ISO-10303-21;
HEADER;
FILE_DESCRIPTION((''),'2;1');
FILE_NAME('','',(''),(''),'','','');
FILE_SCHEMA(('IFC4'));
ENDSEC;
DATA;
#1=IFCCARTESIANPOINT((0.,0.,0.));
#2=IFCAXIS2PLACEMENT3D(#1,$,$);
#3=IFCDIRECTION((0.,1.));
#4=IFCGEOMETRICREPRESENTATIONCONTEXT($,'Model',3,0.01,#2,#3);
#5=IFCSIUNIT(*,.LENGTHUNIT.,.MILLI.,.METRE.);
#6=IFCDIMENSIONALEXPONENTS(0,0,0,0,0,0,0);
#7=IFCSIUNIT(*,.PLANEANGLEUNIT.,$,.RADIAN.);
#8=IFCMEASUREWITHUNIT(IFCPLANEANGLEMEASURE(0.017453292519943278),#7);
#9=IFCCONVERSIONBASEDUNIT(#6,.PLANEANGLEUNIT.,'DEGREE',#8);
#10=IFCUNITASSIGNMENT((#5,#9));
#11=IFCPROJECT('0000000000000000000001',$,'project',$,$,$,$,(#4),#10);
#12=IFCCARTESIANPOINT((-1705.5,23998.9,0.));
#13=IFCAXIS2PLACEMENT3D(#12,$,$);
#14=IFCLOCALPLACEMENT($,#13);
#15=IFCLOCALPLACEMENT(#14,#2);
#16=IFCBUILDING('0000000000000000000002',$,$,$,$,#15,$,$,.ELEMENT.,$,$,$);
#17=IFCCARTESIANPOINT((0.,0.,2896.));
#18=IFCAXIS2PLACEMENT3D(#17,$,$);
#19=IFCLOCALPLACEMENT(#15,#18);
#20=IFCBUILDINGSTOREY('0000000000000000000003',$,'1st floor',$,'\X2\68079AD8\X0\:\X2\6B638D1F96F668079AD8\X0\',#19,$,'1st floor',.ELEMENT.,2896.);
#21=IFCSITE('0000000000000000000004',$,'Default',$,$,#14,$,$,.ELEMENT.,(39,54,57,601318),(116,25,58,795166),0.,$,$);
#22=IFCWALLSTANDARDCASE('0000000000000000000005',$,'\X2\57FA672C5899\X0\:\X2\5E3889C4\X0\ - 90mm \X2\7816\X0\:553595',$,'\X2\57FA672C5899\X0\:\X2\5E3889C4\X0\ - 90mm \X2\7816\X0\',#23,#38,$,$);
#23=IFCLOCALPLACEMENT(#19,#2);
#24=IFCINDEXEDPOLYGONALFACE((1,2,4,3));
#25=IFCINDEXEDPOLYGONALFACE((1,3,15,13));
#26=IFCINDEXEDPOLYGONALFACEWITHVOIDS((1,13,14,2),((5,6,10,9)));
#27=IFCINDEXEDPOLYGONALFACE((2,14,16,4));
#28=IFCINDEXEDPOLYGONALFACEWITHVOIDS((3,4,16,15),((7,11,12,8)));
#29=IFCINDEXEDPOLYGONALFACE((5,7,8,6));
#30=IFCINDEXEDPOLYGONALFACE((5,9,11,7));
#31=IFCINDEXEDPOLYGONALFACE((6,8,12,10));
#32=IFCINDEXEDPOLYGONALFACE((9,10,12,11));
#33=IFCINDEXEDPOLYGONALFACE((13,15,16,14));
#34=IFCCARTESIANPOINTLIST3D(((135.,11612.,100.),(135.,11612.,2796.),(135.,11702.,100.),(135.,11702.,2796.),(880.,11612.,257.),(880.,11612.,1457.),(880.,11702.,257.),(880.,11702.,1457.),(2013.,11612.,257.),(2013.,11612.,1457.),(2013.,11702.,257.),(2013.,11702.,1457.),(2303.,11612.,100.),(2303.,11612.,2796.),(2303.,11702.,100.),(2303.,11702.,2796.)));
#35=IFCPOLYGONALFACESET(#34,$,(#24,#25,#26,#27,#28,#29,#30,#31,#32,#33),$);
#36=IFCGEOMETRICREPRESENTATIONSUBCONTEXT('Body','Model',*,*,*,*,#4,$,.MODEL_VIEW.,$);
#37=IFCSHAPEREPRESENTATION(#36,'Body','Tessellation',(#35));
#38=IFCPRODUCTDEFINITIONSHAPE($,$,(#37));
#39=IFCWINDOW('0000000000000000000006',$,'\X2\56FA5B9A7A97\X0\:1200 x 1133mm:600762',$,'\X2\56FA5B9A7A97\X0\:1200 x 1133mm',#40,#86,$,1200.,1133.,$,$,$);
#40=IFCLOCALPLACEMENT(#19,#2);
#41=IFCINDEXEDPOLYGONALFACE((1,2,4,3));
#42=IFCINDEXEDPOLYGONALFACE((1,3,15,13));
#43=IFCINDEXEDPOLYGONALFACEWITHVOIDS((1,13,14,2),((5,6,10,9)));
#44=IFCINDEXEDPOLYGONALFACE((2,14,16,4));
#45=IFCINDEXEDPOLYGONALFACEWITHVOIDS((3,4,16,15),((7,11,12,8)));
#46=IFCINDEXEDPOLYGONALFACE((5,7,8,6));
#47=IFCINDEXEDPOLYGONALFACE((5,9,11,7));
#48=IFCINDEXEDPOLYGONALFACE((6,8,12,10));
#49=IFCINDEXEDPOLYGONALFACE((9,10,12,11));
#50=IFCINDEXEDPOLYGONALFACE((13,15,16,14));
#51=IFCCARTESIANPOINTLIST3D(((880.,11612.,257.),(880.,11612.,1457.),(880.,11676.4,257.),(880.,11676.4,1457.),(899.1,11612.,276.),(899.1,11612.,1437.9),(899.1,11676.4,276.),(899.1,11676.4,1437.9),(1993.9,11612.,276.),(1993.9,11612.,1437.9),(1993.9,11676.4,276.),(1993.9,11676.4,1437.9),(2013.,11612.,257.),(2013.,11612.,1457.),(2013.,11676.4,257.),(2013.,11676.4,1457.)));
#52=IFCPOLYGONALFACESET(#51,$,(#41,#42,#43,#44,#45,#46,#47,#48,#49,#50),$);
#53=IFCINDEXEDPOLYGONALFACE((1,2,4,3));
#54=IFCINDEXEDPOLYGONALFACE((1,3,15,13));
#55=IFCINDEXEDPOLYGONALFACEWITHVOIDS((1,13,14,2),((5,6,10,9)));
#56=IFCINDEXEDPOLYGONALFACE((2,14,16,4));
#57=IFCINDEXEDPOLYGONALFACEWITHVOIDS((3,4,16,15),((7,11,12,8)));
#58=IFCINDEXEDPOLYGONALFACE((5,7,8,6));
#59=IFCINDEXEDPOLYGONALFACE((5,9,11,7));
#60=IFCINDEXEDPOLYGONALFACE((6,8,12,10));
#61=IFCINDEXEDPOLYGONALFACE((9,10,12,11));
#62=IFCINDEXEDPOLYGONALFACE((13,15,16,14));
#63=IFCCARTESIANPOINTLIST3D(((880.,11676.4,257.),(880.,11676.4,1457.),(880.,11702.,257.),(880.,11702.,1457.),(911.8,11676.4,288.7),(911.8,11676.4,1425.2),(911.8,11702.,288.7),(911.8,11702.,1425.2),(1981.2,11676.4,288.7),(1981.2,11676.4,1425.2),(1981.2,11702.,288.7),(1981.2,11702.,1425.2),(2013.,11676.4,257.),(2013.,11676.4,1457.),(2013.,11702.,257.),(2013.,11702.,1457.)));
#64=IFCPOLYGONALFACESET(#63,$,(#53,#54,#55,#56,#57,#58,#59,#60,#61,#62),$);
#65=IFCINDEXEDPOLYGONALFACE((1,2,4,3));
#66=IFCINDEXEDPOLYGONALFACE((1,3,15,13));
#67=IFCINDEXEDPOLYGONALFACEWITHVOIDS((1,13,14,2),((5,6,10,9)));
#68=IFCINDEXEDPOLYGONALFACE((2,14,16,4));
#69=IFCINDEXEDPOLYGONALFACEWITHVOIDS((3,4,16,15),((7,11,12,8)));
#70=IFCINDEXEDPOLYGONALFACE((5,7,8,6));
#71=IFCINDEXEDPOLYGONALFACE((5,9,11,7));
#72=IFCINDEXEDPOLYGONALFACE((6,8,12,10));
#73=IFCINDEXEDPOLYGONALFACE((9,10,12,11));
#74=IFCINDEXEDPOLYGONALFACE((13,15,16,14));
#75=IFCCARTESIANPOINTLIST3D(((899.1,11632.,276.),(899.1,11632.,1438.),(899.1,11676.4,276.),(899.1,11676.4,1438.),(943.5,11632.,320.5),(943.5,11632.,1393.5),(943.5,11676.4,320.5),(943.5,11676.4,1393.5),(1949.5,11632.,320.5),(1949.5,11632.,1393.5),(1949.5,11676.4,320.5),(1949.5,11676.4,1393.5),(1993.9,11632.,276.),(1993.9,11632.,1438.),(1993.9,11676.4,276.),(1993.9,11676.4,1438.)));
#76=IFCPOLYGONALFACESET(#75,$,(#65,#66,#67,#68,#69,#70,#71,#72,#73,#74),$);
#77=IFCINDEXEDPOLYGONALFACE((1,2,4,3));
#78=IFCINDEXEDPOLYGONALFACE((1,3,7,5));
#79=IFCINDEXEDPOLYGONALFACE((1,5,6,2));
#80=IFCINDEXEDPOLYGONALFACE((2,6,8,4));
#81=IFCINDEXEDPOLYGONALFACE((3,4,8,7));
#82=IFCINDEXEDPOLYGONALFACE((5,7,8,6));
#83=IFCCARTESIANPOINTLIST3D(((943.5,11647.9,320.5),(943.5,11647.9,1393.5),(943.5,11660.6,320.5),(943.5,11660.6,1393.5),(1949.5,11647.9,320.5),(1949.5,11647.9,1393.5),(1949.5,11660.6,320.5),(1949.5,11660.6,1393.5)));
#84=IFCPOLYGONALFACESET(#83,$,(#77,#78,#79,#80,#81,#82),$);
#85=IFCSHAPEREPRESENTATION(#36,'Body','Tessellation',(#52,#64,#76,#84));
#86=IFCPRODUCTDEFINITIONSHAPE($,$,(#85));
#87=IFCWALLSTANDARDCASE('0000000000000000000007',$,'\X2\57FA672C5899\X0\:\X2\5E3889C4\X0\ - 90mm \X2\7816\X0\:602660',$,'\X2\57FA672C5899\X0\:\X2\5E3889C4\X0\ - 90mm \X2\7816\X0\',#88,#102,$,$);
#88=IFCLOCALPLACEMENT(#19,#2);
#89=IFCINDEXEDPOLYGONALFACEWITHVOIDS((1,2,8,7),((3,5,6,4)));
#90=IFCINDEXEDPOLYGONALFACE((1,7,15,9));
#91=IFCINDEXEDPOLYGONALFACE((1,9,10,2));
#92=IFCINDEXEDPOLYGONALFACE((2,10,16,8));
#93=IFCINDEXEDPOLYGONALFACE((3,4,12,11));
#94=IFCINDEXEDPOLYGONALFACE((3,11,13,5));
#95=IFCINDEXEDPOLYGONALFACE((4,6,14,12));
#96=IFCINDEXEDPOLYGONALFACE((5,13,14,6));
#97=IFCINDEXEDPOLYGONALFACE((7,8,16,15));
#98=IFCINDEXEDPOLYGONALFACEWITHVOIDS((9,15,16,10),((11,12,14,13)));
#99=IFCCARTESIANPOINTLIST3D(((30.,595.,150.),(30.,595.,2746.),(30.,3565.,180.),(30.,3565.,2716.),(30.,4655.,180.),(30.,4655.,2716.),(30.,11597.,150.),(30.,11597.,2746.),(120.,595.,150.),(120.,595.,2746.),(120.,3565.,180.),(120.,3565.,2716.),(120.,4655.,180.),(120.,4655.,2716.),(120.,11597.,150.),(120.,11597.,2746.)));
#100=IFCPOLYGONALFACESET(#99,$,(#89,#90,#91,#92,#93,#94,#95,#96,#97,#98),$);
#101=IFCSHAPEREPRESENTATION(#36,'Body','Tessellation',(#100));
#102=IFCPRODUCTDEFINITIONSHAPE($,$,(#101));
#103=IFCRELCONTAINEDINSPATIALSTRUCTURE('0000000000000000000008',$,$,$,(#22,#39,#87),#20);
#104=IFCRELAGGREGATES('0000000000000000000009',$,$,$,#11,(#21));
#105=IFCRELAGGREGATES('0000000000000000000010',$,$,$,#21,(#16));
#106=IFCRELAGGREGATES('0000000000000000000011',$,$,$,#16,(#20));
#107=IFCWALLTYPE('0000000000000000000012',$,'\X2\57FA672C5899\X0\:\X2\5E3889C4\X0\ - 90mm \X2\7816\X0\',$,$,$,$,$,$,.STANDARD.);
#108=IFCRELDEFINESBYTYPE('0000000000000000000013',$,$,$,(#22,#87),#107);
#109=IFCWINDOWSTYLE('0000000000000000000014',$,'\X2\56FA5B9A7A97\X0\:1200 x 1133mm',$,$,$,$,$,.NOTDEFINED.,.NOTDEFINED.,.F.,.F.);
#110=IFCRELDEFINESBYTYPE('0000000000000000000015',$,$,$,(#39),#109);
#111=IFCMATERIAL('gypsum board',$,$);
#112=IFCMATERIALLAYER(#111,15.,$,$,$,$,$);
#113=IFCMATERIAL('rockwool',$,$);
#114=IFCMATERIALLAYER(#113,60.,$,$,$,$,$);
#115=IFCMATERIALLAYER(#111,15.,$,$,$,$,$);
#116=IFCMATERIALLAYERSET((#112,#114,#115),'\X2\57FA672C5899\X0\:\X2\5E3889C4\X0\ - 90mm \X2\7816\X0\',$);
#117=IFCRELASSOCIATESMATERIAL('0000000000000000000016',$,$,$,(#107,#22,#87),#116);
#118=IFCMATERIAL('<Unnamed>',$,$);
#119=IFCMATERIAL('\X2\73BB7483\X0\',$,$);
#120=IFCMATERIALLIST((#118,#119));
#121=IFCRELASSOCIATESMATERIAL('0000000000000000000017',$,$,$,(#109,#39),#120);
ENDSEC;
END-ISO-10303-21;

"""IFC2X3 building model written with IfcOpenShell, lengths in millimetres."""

from ifc_helpers import new_model, entity, si_unit, converted_unit, direction, frame, frame_2d, origin, origin_2d_with_axis, place, context, subcontext, project, spatial, polyline, rectangle, outline, extrude, source, transform, mapped, material, material_list, layer, layer_set, layer_usage, type_object, type_shapes, element, fill, save


model = new_model("IFC2X3")

# Units and contexts
model_context = context("Model", 3, precision=0.01, world=origin(), true_north=direction((0.0, 1.0)))
body_context = subcontext(model_context, "Body", "Model", "MODEL_VIEW")
ifc_project = project(units=[si_unit("LENGTHUNIT", "METRE", prefix="MILLI"), converted_unit("PLANEANGLEUNIT", "DEGREE", entity("IfcPlaneAngleMeasure", 0.017453292519943278), si_unit("PLANEANGLEUNIT", "RADIAN"), dimensions=[0, 0, 0, 0, 0, 0, 0])], contexts=[model_context])

# Site, building, storey
site_placement = place(None, frame((-1705.5, 23998.9, 0.0)))
site = spatial("IfcSite", under=ifc_project, at=site_placement, Name="Default", CompositionType="ELEMENT", RefLatitude=(39, 54, 57, 601318), RefLongitude=(116, 25, 58, 795166), RefElevation=0.0)
building_placement = place(site_placement, origin())
building = spatial("IfcBuilding", under=site, at=building_placement, CompositionType="ELEMENT")
storey_placement = place(building_placement, frame((0.0, 0.0, 2896.0)))
storey = spatial("IfcBuildingStorey", under=building, at=storey_placement, Name="1st floor", ObjectType="标高:正负零标高", LongName="1st floor", CompositionType="ELEMENT", Elevation=2896.0)

# Shared definitions
ifc_material_1 = material(Name="gypsum board")
ifc_layer_1 = layer(ifc_material_1, 15.0)
ifc_material_2 = material(Name="rockwool")
ifc_layer_2 = layer(ifc_material_2, 60.0)
ifc_layer_3 = layer(ifc_material_1, 15.0)
ifc_layer_set = layer_set([ifc_layer_1, ifc_layer_2, ifc_layer_3], Name="基本墙:常规 - 90mm 砖")
wall_type = type_object("IfcWallType", Name="基本墙:常规 - 90mm 砖", PredefinedType="STANDARD", material=ifc_layer_set)

# Wall, opening, window
ifc_layer_usage_1 = layer_usage(ifc_layer_set, "AXIS2", "NEGATIVE", 45.0)
wall_1_placement = place(storey_placement, frame((2303.0, 11657.0, 100.0), z_axis=(0.0, 0.0, 1.0), x_axis=(-1.0, 0.0, 0.0)))
wall_1 = element("IfcWallStandardCase", 1, at=wall_1_placement, inside=storey, type_object=wall_type, material=ifc_layer_usage_1, Name="基本墙:常规 - 90mm 砖:553595", ObjectType="基本墙:常规 - 90mm 砖", context=body_context, shape_type="SweptSolid", body=[
    extrude(rectangle(XDim=2168.0, YDim=90.0, at=frame_2d((1084.0, 0.0), x_axis=(-1.0, 0.0))), origin(), (0.0, 0.0, 1.0), 2696.0),
])
opening_1_placement = place(wall_1_placement, frame((290.0, -45.0, 157.0)))
opening_1 = element("IfcOpeningElement", 2, at=opening_1_placement, cuts=wall_1, ObjectType="Opening", context=body_context, shape_type="SweptSolid", body=[
    extrude(rectangle(XDim=1200.0, YDim=1133.0, at=frame_2d((600.0, 566.5), x_axis=(-1.0, 0.0))), frame((0.0, 0.0, 0.0), z_axis=(0.0, 1.0, 0.0), x_axis=(0.0, 0.0, 1.0)), (0.0, 0.0, 1.0), 90.0),
])
ifc_material_3 = material(Name="<Unnamed>")
ifc_material_4 = material(Name="玻璃")
ifc_material_list = material_list([ifc_material_3, ifc_material_4])
window_style = type_object("IfcWindowStyle", Name="固定窗:1200 x 1133mm", ConstructionType="NOTDEFINED", OperationType="NOTDEFINED", ParameterTakesPrecedence=False, Sizeable=False, material=ifc_material_list)
shared_shape = source(origin(), body_context, "Body", "SweptSolid", [
    extrude(outline(polyline([(-600.0, -566.5), (600.0, -566.5), (600.0, 566.5), (-600.0, 566.5), (-600.0, -566.5)]), holes=[polyline([(-580.9, -547.4), (-580.9, 547.5), (581.0, 547.5), (581.0, -547.4), (-580.9, -547.4)])]), frame((566.5, 25.5, 600.0), z_axis=(0.0, 1.0, 0.0), x_axis=(0.0, 0.0, -1.0)), (0.0, 0.0, 1.0), 64.4),
    extrude(outline(polyline([(-566.5, -600.0), (566.5, -600.0), (566.5, 600.0), (-566.5, 600.0), (-566.5, -600.0)]), holes=[polyline([(-534.8, -568.2), (-534.8, 568.3), (534.7, 568.3), (534.7, -568.2), (-534.8, -568.2)])]), frame((566.5, 0.0, 600.0), z_axis=(0.0, 1.0, 0.0), x_axis=(1.0, 0.0, 0.0)), (0.0, 0.0, 1.0), 25.5),
    extrude(outline(polyline([(-547.4, -581.0), (547.4, -581.0), (547.4, 581.0), (-547.4, 581.0), (-547.4, -581.0)]), holes=[polyline([(-503.0, -536.5), (-503.0, 536.5), (503.0, 536.5), (503.0, -536.5), (-503.0, -536.5)])]), frame((566.5, 25.5, 600.0), z_axis=(0.0, 1.0, 0.0), x_axis=(1.0, 0.0, 0.0)), (0.0, 0.0, 1.0), 44.4),
    extrude(rectangle(XDim=12.7, YDim=1006.0, at=origin_2d_with_axis()), frame((566.5, 47.8, 63.5), z_axis=(0.0, 0.0, 1.0), x_axis=(0.0, 1.0, 0.0)), (0.0, 0.0, 1.0), 1073.0),
])
type_shapes(window_style, [shared_shape])
window_placement = place(opening_1_placement, origin())
window = element("IfcWindow", 3, at=window_placement, inside=storey, type_object=window_style, material=ifc_material_list, Name="固定窗:1200 x 1133mm:600762", ObjectType="固定窗:1200 x 1133mm", OverallHeight=1200.0, OverallWidth=1133.0, context=body_context, shape_type="MappedRepresentation", body=[
    mapped(shared_shape, transform((0.0, 0.0, 0.0), scale=1.0)),
])
fill(opening_1, window)

# Wall, opening
ifc_layer_usage_2 = layer_usage(ifc_layer_set, "AXIS2", "NEGATIVE", 45.0)
wall_2_placement = place(storey_placement, frame((75.0, 11597.0, 150.0), z_axis=(0.0, 0.0, 1.0), x_axis=(0.0, -1.0, 0.0)))
wall_2 = element("IfcWallStandardCase", 4, at=wall_2_placement, inside=storey, type_object=wall_type, material=ifc_layer_usage_2, Name="基本墙:常规 - 90mm 砖:602660", ObjectType="基本墙:常规 - 90mm 砖", context=body_context, shape_type="SweptSolid", body=[
    extrude(rectangle(XDim=11002.0, YDim=90.0, at=frame_2d((5501.0, 0.0), x_axis=(-1.0, 0.0))), origin(), (0.0, 0.0, 1.0), 2596.0),
])
opening_2_placement = place(wall_2_placement, origin())
element("IfcOpeningElement", 5, at=opening_2_placement, cuts=wall_2, ObjectType="Opening", context=body_context, shape_type="SweptSolid", body=[
    extrude(rectangle(XDim=2536.0, YDim=1090.0, at=frame_2d((0.0, 0.0), x_axis=(0.0, 1.0))), frame((7487.0, 45.0, 1298.0), z_axis=(0.0, -1.0, 0.0), x_axis=(-1.0, 0.0, 0.0)), (0.0, 0.0, 1.0), 90.0),
])

save(model, "model.ifc")
